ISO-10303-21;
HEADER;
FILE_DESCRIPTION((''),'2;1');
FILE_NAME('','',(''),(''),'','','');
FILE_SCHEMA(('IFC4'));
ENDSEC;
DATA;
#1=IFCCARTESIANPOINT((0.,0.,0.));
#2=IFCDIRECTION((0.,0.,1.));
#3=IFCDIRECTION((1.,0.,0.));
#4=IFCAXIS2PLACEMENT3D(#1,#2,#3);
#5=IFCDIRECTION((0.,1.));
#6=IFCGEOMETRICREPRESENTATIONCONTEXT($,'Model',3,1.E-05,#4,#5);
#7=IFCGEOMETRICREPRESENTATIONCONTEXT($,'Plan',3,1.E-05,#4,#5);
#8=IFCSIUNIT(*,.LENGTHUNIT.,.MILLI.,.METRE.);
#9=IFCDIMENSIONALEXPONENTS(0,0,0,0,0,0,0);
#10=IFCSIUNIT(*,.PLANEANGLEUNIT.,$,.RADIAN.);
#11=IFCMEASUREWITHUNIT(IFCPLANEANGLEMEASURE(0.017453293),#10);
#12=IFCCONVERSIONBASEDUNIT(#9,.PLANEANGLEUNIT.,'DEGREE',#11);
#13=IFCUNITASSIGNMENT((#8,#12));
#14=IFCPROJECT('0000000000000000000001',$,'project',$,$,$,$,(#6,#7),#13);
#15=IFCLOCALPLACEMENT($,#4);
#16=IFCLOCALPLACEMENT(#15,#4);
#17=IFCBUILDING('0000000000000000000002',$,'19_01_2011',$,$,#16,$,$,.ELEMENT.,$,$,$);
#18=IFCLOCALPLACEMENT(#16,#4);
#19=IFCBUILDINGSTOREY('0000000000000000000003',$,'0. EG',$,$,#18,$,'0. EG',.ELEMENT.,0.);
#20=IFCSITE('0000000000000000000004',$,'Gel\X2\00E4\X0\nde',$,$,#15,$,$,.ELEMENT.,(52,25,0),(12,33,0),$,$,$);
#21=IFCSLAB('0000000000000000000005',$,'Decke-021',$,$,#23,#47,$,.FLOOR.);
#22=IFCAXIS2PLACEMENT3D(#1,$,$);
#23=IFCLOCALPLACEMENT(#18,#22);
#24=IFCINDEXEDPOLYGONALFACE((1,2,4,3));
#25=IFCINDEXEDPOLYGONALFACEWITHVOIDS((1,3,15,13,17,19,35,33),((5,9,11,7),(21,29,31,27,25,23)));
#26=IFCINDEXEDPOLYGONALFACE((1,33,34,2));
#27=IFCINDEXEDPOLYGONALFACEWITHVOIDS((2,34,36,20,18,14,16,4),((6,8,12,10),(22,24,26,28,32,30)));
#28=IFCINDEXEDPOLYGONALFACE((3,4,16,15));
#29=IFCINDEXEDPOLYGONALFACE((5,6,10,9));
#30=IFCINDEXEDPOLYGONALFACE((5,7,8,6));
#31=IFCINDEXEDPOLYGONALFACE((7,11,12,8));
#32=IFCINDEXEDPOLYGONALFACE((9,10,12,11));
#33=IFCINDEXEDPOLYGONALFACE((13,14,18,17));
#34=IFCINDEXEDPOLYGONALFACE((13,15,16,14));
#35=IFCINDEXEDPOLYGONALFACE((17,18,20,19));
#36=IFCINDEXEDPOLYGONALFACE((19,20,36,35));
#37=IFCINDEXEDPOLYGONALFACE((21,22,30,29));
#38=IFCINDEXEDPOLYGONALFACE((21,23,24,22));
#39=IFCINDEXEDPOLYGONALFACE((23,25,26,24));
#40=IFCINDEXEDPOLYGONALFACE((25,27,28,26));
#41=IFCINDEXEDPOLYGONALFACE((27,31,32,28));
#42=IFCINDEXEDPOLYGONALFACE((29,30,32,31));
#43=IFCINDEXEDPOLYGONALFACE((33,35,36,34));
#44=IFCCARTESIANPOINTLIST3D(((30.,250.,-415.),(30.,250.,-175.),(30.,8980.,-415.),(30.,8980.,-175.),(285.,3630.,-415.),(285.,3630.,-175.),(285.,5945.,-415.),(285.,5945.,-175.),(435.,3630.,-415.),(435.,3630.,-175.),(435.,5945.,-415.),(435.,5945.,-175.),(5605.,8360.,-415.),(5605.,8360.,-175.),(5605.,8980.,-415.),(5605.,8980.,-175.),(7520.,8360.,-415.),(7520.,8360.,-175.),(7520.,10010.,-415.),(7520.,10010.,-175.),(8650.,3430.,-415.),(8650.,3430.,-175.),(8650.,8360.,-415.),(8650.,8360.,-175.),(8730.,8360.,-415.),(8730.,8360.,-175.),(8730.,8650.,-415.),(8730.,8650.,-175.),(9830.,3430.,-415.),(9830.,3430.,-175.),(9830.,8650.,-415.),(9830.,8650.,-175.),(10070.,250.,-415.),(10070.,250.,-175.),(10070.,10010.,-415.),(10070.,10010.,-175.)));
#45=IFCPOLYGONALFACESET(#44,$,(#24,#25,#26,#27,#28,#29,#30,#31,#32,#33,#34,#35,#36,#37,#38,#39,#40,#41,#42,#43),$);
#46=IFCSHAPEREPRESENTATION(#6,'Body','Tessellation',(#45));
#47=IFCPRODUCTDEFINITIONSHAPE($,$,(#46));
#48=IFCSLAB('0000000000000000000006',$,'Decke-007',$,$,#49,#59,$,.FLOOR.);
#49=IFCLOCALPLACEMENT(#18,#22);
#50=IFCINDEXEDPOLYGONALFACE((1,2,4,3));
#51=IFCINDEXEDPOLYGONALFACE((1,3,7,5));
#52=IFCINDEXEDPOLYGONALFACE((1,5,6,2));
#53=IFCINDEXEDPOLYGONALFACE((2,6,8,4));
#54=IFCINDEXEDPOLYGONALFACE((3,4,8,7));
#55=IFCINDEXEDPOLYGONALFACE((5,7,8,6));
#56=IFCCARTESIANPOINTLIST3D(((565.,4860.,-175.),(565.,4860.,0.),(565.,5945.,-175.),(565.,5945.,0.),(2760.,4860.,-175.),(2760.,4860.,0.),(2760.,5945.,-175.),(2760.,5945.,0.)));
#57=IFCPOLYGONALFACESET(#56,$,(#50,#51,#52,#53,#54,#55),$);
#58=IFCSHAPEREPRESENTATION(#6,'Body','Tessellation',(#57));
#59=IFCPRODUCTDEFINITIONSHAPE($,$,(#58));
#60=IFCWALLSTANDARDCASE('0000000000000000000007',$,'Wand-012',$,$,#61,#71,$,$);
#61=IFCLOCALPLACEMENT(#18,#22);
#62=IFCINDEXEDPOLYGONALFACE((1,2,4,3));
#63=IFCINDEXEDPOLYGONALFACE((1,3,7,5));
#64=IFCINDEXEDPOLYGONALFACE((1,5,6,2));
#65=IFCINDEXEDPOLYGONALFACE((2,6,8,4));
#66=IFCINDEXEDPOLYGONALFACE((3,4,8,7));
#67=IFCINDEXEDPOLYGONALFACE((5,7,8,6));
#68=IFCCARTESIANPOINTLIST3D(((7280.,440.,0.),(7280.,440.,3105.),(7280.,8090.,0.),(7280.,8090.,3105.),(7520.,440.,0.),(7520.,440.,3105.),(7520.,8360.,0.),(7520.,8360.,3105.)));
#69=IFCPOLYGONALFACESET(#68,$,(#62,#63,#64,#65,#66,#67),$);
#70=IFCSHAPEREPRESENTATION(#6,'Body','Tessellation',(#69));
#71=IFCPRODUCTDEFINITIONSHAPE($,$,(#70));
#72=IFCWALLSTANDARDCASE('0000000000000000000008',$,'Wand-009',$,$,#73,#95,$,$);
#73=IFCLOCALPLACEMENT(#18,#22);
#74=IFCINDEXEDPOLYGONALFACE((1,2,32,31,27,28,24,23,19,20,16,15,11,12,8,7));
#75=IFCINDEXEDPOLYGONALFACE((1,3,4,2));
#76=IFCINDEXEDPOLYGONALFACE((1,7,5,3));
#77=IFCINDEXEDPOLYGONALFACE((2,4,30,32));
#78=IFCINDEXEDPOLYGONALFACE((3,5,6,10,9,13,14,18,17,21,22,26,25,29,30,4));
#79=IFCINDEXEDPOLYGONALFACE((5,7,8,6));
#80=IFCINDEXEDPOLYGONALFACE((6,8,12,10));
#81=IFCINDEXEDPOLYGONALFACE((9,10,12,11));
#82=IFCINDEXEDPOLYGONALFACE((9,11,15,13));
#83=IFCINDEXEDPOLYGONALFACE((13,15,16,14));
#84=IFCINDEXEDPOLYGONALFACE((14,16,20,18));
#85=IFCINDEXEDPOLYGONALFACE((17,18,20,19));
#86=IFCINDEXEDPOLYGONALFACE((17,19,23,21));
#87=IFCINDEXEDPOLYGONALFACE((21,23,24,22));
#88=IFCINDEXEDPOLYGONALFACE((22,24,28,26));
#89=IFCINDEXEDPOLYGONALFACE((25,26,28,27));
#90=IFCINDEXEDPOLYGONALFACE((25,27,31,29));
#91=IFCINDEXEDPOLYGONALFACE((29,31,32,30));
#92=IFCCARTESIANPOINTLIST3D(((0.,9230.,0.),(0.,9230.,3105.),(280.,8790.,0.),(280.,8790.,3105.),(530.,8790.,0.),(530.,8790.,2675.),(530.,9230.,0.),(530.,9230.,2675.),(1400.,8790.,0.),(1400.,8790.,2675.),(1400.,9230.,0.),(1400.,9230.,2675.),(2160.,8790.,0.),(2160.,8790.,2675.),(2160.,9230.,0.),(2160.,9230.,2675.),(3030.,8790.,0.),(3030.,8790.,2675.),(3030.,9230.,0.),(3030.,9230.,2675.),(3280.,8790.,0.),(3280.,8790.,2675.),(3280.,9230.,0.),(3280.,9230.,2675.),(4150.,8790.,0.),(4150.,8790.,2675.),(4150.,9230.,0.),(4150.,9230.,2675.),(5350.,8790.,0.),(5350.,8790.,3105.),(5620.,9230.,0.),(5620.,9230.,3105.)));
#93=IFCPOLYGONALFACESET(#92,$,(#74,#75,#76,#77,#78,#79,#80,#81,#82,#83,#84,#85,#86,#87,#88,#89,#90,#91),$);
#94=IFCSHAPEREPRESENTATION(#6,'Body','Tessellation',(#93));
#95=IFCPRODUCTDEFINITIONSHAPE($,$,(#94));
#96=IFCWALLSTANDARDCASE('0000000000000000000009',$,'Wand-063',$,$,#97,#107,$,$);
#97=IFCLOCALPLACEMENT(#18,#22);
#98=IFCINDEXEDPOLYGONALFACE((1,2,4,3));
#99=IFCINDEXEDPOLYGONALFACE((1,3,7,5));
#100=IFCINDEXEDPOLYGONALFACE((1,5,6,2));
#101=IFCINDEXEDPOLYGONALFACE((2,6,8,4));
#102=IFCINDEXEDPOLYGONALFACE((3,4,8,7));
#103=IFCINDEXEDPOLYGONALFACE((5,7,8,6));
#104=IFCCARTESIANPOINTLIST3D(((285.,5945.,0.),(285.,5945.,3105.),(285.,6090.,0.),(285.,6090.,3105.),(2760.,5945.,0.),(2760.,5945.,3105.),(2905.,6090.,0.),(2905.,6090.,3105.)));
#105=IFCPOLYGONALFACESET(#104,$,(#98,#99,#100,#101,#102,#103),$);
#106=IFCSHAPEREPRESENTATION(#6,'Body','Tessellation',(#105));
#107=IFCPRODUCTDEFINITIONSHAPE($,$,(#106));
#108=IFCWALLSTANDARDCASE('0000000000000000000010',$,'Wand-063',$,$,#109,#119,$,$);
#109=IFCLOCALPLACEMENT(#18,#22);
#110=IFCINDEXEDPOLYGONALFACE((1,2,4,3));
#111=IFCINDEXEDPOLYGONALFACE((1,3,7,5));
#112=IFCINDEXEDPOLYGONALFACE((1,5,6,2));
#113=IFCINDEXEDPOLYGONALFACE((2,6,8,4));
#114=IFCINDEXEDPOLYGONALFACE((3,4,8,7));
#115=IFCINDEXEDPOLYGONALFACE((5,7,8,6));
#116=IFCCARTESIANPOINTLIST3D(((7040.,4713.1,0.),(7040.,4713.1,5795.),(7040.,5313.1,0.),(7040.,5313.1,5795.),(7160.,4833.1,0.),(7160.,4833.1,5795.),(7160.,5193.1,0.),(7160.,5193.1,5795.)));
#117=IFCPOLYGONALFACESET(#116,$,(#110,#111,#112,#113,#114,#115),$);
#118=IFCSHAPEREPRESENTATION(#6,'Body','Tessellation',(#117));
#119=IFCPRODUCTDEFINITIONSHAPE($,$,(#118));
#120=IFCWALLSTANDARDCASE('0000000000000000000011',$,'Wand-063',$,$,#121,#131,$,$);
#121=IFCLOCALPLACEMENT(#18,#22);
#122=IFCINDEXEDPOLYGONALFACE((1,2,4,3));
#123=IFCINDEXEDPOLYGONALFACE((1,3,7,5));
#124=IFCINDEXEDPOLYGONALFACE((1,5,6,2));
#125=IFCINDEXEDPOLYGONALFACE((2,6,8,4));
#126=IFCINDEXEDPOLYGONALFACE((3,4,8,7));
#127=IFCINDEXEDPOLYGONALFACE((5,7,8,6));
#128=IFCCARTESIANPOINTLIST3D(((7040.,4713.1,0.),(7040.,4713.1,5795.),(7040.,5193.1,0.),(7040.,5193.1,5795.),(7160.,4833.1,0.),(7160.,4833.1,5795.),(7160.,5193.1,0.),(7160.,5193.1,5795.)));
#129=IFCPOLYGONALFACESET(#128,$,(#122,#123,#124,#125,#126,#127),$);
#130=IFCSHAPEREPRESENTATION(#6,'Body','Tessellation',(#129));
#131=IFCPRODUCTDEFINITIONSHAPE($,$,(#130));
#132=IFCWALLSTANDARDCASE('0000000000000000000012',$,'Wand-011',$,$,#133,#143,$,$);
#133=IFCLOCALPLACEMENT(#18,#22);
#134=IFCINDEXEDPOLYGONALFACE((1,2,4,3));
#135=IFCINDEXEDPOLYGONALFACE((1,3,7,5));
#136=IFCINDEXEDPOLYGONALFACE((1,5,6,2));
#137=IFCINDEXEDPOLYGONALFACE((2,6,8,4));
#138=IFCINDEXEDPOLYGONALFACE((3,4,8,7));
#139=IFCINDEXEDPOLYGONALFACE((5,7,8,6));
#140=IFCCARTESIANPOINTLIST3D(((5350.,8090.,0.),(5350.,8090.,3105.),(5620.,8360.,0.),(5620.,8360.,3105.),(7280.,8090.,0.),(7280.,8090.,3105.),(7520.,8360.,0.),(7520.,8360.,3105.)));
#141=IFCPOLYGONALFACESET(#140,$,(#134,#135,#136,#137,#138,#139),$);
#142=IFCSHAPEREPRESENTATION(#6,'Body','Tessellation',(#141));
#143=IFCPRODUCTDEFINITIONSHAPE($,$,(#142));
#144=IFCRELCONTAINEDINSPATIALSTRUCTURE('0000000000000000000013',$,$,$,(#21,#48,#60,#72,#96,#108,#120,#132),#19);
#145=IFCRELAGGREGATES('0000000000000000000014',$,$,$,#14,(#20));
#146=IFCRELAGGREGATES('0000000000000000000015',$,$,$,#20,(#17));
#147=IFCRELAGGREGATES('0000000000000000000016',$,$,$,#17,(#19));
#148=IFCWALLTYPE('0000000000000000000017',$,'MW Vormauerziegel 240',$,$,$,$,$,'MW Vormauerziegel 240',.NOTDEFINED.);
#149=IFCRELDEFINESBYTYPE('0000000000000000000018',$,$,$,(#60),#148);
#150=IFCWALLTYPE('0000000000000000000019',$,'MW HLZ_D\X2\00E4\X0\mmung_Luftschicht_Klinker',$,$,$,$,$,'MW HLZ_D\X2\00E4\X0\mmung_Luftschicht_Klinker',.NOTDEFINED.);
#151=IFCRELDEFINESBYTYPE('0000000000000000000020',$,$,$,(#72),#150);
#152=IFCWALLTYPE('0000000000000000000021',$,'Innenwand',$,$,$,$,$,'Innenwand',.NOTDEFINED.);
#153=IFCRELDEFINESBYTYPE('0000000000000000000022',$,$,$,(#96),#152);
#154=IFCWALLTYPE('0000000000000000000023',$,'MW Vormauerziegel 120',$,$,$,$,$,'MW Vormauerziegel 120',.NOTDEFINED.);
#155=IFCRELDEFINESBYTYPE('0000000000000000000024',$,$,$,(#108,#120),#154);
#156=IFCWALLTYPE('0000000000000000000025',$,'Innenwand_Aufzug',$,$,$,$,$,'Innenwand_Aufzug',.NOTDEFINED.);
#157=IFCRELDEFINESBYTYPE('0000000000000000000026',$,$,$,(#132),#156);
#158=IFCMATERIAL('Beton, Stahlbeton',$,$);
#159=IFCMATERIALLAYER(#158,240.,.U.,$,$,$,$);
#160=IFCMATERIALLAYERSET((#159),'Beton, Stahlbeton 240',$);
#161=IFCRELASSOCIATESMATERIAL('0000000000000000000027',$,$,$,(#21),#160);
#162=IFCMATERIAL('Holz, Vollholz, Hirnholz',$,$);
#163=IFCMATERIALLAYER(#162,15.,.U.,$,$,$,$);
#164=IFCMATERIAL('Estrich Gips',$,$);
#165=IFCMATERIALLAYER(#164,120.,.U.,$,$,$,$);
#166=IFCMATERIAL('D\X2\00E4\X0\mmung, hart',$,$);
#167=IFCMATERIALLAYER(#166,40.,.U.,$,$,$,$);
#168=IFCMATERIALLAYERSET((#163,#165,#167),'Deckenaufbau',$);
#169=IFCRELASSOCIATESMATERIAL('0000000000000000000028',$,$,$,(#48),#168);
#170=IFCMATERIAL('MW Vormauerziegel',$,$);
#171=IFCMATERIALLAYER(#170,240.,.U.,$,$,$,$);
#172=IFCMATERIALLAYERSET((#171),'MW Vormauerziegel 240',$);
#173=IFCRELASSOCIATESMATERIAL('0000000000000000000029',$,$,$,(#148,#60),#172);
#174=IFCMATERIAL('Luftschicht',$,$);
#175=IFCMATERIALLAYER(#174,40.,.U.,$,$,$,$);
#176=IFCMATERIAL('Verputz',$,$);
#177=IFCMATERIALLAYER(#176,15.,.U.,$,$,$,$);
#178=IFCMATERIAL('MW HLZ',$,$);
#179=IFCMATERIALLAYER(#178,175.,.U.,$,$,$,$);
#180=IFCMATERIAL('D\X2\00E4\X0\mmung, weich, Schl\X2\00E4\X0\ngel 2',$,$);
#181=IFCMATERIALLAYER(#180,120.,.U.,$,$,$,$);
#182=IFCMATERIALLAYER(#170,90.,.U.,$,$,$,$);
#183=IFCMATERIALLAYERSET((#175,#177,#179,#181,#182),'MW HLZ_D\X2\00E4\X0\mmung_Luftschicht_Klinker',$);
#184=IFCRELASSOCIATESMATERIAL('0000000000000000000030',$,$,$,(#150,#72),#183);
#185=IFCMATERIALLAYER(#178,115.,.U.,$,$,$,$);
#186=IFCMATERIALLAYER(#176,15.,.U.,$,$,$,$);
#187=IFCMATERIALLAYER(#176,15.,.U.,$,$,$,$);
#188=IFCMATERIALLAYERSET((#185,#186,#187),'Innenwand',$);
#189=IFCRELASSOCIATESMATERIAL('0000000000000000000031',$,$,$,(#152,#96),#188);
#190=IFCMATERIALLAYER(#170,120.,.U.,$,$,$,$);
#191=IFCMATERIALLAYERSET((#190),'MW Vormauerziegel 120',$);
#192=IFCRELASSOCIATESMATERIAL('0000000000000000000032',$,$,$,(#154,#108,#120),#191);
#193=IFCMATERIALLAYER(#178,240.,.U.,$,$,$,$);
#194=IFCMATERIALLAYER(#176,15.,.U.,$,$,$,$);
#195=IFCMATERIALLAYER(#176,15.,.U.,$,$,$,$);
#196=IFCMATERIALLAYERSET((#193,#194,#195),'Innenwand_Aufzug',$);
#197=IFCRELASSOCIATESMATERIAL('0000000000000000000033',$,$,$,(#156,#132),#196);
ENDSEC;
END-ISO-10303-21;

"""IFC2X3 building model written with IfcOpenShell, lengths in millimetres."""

from ifc_helpers import new_model, entity, si_unit, converted_unit, direction, frame, frame_2d, origin_with_axes, place, context, project, spatial, polyline, rectangle, outline, extrude, material, layer, layer_set, layer_usage, type_object, element, save


model = new_model("IFC2X3")

# Units and contexts
model_context = context("Model", 3, precision=1e-05, world=origin_with_axes(), true_north=direction((0.0, 1.0)))
plan_context = context("Plan", 3, precision=1e-05, world=origin_with_axes(), true_north=direction((0.0, 1.0)))
ifc_project = project(units=[si_unit("LENGTHUNIT", "METRE", prefix="MILLI"), converted_unit("PLANEANGLEUNIT", "DEGREE", entity("IfcPlaneAngleMeasure", 0.017453293), si_unit("PLANEANGLEUNIT", "RADIAN"), dimensions=[0, 0, 0, 0, 0, 0, 0])], contexts=[model_context, plan_context])

# Site, building, storey
site_placement = place(None, origin_with_axes())
site = spatial("IfcSite", under=ifc_project, at=site_placement, Name="Gelände", CompositionType="ELEMENT", RefLatitude=(52, 25, 0), RefLongitude=(12, 33, 0))
building_placement = place(site_placement, origin_with_axes())
building = spatial("IfcBuilding", under=site, at=building_placement, Name="19_01_2011", CompositionType="ELEMENT")
storey_placement = place(building_placement, origin_with_axes())
storey = spatial("IfcBuildingStorey", under=building, at=storey_placement, Name="0. EG", LongName="0. EG", CompositionType="ELEMENT", Elevation=0.0)

# Slab, openings
ifc_material_1 = material(Name="Beton, Stahlbeton")
ifc_layer_1 = layer(ifc_material_1, 240.0, ventilated="UNKNOWN")
ifc_layer_set_1 = layer_set([ifc_layer_1], Name="Beton, Stahlbeton 240")
ifc_layer_usage_1 = layer_usage(ifc_layer_set_1, "AXIS3", "NEGATIVE", 240.0)
slab_1_placement = place(storey_placement, frame((30.0, 8980.0, -415.0), z_axis=(0.0, 0.0, 1.0), x_axis=(0.0, -1.0, 0.0)))
slab_1 = element("IfcSlab", 1, at=slab_1_placement, inside=storey, material=ifc_layer_usage_1, Name="Decke-021", PredefinedType="FLOOR", context=model_context, shape_type="SweptSolid", body=[
    extrude(outline(polyline([(0.0, 0.0), (8730.0, 0.0), (8730.0, 10040.0), (-1030.0, 10040.0), (-1030.0, 7490.0), (620.0, 7490.0), (620.0, 5575.0), (0.0, 5575.0), (0.0, 0.0)])), origin_with_axes(), (0.0, 0.0, 1.0), 240.0),
])
opening_1_placement = place(slab_1_placement, origin_with_axes())
element("IfcOpeningElement", 2, at=opening_1_placement, cuts=slab_1, context=model_context, shape_type="SweptSolid", body=[
    extrude(outline(polyline([(5550.0, 8620.0), (620.0, 8620.0), (620.0, 8700.0), (330.0, 8700.0), (330.0, 9800.0), (5550.0, 9800.0), (5550.0, 8620.0)])), origin_with_axes(), (0.0, 0.0, 1.0), 240.0),
])
opening_2_placement = place(slab_1_placement, origin_with_axes())
element("IfcOpeningElement", 3, at=opening_2_placement, cuts=slab_1, context=model_context, shape_type="SweptSolid", body=[
    extrude(outline(polyline([(5350.0, 255.0), (3035.0, 255.0), (3035.0, 405.0), (5350.0, 405.0), (5350.0, 255.0)])), origin_with_axes(), (0.0, 0.0, 1.0), 240.0),
])

# Slab
ifc_material_2 = material(Name="Holz, Vollholz, Hirnholz")
ifc_layer_2 = layer(ifc_material_2, 15.0, ventilated="UNKNOWN")
ifc_material_3 = material(Name="Estrich Gips")
ifc_layer_3 = layer(ifc_material_3, 120.0, ventilated="UNKNOWN")
ifc_material_4 = material(Name="Dämmung, hart")
ifc_layer_4 = layer(ifc_material_4, 40.0, ventilated="UNKNOWN")
ifc_layer_set_2 = layer_set([ifc_layer_2, ifc_layer_3, ifc_layer_4], Name="Deckenaufbau")
ifc_layer_usage_2 = layer_usage(ifc_layer_set_2, "AXIS3", "NEGATIVE", 175.0)
slab_2_placement = place(storey_placement, frame((565.0, 5945.0, -175.0), z_axis=(0.0, 0.0, 1.0), x_axis=(1.0, 0.0, 0.0)))
element("IfcSlab", 4, at=slab_2_placement, inside=storey, material=ifc_layer_usage_2, Name="Decke-007", PredefinedType="FLOOR", context=model_context, shape_type="SweptSolid", body=[
    extrude(outline(polyline([(0.0, 0.0), (2195.0, 0.0), (2195.0, -1085.0), (0.0, -1085.0), (0.0, 0.0)])), origin_with_axes(), (0.0, 0.0, 1.0), 175.0),
])

# Wall
ifc_material_5 = material(Name="MW Vormauerziegel")
ifc_layer_5 = layer(ifc_material_5, 240.0, ventilated="UNKNOWN")
ifc_layer_set_3 = layer_set([ifc_layer_5], Name="MW Vormauerziegel 240")
ifc_layer_usage_3 = layer_usage(ifc_layer_set_3, "AXIS2", "NEGATIVE", 0.0)
wall_type_1 = type_object("IfcWallType", Name="MW Vormauerziegel 240", ElementType="MW Vormauerziegel 240", PredefinedType="NOTDEFINED", material=ifc_layer_set_3)
wall_1_placement = place(storey_placement, frame((7520.0, 8360.0, 0.0), z_axis=(0.0, 0.0, 1.0), x_axis=(0.0, -1.0, 0.0)))
element("IfcWallStandardCase", 5, at=wall_1_placement, inside=storey, type_object=wall_type_1, material=ifc_layer_usage_3, Name="Wand-012", context=model_context, shape_type="SweptSolid", body=[
    extrude(outline(polyline([(270.0, -240.0), (7920.0, -240.0), (7920.0, 0.0), (0.0, 0.0), (270.0, -240.0)])), origin_with_axes(), (0.0, 0.0, 1.0), 3105.0),
])

# Wall, openings
ifc_material_6 = material(Name="Luftschicht")
ifc_layer_6 = layer(ifc_material_6, 40.0, ventilated="UNKNOWN")
ifc_material_7 = material(Name="Verputz")
ifc_layer_7 = layer(ifc_material_7, 15.0, ventilated="UNKNOWN")
ifc_material_8 = material(Name="MW HLZ")
ifc_layer_8 = layer(ifc_material_8, 175.0, ventilated="UNKNOWN")
ifc_material_9 = material(Name="Dämmung, weich, Schlängel 2")
ifc_layer_9 = layer(ifc_material_9, 120.0, ventilated="UNKNOWN")
ifc_layer_10 = layer(ifc_material_5, 90.0, ventilated="UNKNOWN")
ifc_layer_set_4 = layer_set([ifc_layer_6, ifc_layer_7, ifc_layer_8, ifc_layer_9, ifc_layer_10], Name="MW HLZ_Dämmung_Luftschicht_Klinker")
ifc_layer_usage_4 = layer_usage(ifc_layer_set_4, "AXIS2", "NEGATIVE", 0.0)
wall_type_2 = type_object("IfcWallType", Name="MW HLZ_Dämmung_Luftschicht_Klinker", ElementType="MW HLZ_Dämmung_Luftschicht_Klinker", PredefinedType="NOTDEFINED", material=ifc_layer_set_4)
wall_2_placement = place(storey_placement, frame((0.0, 9230.0, 0.0), z_axis=(0.0, 0.0, 1.0), x_axis=(1.0, 0.0, 0.0)))
wall_2 = element("IfcWallStandardCase", 6, at=wall_2_placement, inside=storey, type_object=wall_type_2, material=ifc_layer_usage_4, Name="Wand-009", context=model_context, shape_type="SweptSolid", body=[
    extrude(outline(polyline([(280.0, -440.0), (5350.0, -440.0), (5620.0, 0.0), (0.0, 0.0), (280.0, -440.0)])), origin_with_axes(), (0.0, 0.0, 1.0), 3105.0),
])
opening_3_placement = place(wall_2_placement, frame((3715.0, -440.0, 0.0), z_axis=(0.0, 0.0, 1.0), x_axis=(1.0, 0.0, 0.0)))
element("IfcOpeningElement", 7, at=opening_3_placement, cuts=wall_2, ObjectType="Opening", context=model_context, shape_type="SweptSolid", body=[
    extrude(rectangle(XDim=870.0, YDim=2675.0, at=frame_2d((0.0, 1337.5), x_axis=(-1.0, 0.0))), frame((0.0, 0.0, 0.0), z_axis=(0.0, 1.0, 0.0), x_axis=(-1.0, 0.0, 0.0)), (0.0, 0.0, 1.0), 440.0),
])
opening_4_placement = place(wall_2_placement, frame((965.0, -440.0, 0.0), z_axis=(0.0, 0.0, 1.0), x_axis=(1.0, 0.0, 0.0)))
element("IfcOpeningElement", 8, at=opening_4_placement, cuts=wall_2, ObjectType="Opening", context=model_context, shape_type="SweptSolid", body=[
    extrude(rectangle(XDim=870.0, YDim=2675.0, at=frame_2d((0.0, 1337.5), x_axis=(-1.0, 0.0))), frame((0.0, 0.0, 0.0), z_axis=(0.0, 1.0, 0.0), x_axis=(-1.0, 0.0, 0.0)), (0.0, 0.0, 1.0), 440.0),
])
opening_5_placement = place(wall_2_placement, frame((2595.0, -440.0, 0.0), z_axis=(0.0, 0.0, 1.0), x_axis=(1.0, 0.0, 0.0)))
element("IfcOpeningElement", 9, at=opening_5_placement, cuts=wall_2, ObjectType="Opening", context=model_context, shape_type="SweptSolid", body=[
    extrude(rectangle(XDim=870.0, YDim=2675.0, at=frame_2d((0.0, 1337.5), x_axis=(-1.0, 0.0))), frame((0.0, 0.0, 0.0), z_axis=(0.0, 1.0, 0.0), x_axis=(-1.0, 0.0, 0.0)), (0.0, 0.0, 1.0), 440.0),
])

# Walls
ifc_layer_11 = layer(ifc_material_8, 115.0, ventilated="UNKNOWN")
ifc_layer_12 = layer(ifc_material_7, 15.0, ventilated="UNKNOWN")
ifc_layer_13 = layer(ifc_material_7, 15.0, ventilated="UNKNOWN")
ifc_layer_set_5 = layer_set([ifc_layer_11, ifc_layer_12, ifc_layer_13], Name="Innenwand")
ifc_layer_usage_5 = layer_usage(ifc_layer_set_5, "AXIS2", "NEGATIVE", 0.0)
wall_type_3 = type_object("IfcWallType", Name="Innenwand", ElementType="Innenwand", PredefinedType="NOTDEFINED", material=ifc_layer_set_5)
wall_3_placement = place(storey_placement, frame((2760.0, 5945.0, 0.0), z_axis=(0.0, 0.0, 1.0), x_axis=(-1.0, 0.0, 0.0)))
element("IfcWallStandardCase", 10, at=wall_3_placement, inside=storey, type_object=wall_type_3, material=ifc_layer_usage_5, Name="Wand-063", context=model_context, shape_type="SweptSolid", body=[
    extrude(outline(polyline([(-145.0, -145.0), (2475.0, -145.0), (2475.0, 0.0), (0.0, 0.0), (-145.0, -145.0)])), origin_with_axes(), (0.0, 0.0, 1.0), 3105.0),
])
ifc_layer_14 = layer(ifc_material_5, 120.0, ventilated="UNKNOWN")
ifc_layer_set_6 = layer_set([ifc_layer_14], Name="MW Vormauerziegel 120")
wall_type_4 = type_object("IfcWallType", Name="MW Vormauerziegel 120", ElementType="MW Vormauerziegel 120", PredefinedType="NOTDEFINED", material=ifc_layer_set_6)
ifc_layer_usage_6 = layer_usage(ifc_layer_set_6, "AXIS2", "POSITIVE", 0.0)
wall_4_placement = place(storey_placement, frame((7040.0, 5193.1, 0.0), z_axis=(0.0, 0.0, 1.0), x_axis=(0.0, -1.0, 0.0)))
element("IfcWallStandardCase", 11, at=wall_4_placement, inside=storey, type_object=wall_type_4, material=ifc_layer_usage_6, Name="Wand-063", context=model_context, shape_type="SweptSolid", body=[
    extrude(outline(polyline([(-120.0, 0.0), (480.0, 0.0), (360.0, 120.0), (0.0, 120.0), (-120.0, 0.0)])), origin_with_axes(), (0.0, 0.0, 1.0), 5795.0),
])
ifc_layer_usage_7 = layer_usage(ifc_layer_set_6, "AXIS2", "POSITIVE", 0.0)
wall_5_placement = place(storey_placement, frame((7040.0, 5193.1, 0.0), z_axis=(0.0, 0.0, 1.0), x_axis=(0.0, -1.0, 0.0)))
element("IfcWallStandardCase", 12, at=wall_5_placement, inside=storey, type_object=wall_type_4, material=ifc_layer_usage_7, Name="Wand-063", context=model_context, shape_type="SweptSolid", body=[
    extrude(outline(polyline([(0.0, 0.0), (480.0, 0.0), (360.0, 120.0), (0.0, 120.0), (0.0, 0.0)])), origin_with_axes(), (0.0, 0.0, 1.0), 5795.0),
])
ifc_layer_15 = layer(ifc_material_8, 240.0, ventilated="UNKNOWN")
ifc_layer_16 = layer(ifc_material_7, 15.0, ventilated="UNKNOWN")
ifc_layer_17 = layer(ifc_material_7, 15.0, ventilated="UNKNOWN")
ifc_layer_set_7 = layer_set([ifc_layer_15, ifc_layer_16, ifc_layer_17], Name="Innenwand_Aufzug")
ifc_layer_usage_8 = layer_usage(ifc_layer_set_7, "AXIS2", "NEGATIVE", 0.0)
wall_type_5 = type_object("IfcWallType", Name="Innenwand_Aufzug", ElementType="Innenwand_Aufzug", PredefinedType="NOTDEFINED", material=ifc_layer_set_7)
wall_6_placement = place(storey_placement, frame((5620.0, 8360.0, 0.0), z_axis=(0.0, 0.0, 1.0), x_axis=(1.0, 0.0, 0.0)))
element("IfcWallStandardCase", 13, at=wall_6_placement, inside=storey, type_object=wall_type_5, material=ifc_layer_usage_8, Name="Wand-011", context=model_context, shape_type="SweptSolid", body=[
    extrude(outline(polyline([(-270.0, -270.0), (1660.0, -270.0), (1900.0, 0.0), (0.0, 0.0), (-270.0, -270.0)])), origin_with_axes(), (0.0, 0.0, 1.0), 3105.0),
])

save(model, "model.ifc")
